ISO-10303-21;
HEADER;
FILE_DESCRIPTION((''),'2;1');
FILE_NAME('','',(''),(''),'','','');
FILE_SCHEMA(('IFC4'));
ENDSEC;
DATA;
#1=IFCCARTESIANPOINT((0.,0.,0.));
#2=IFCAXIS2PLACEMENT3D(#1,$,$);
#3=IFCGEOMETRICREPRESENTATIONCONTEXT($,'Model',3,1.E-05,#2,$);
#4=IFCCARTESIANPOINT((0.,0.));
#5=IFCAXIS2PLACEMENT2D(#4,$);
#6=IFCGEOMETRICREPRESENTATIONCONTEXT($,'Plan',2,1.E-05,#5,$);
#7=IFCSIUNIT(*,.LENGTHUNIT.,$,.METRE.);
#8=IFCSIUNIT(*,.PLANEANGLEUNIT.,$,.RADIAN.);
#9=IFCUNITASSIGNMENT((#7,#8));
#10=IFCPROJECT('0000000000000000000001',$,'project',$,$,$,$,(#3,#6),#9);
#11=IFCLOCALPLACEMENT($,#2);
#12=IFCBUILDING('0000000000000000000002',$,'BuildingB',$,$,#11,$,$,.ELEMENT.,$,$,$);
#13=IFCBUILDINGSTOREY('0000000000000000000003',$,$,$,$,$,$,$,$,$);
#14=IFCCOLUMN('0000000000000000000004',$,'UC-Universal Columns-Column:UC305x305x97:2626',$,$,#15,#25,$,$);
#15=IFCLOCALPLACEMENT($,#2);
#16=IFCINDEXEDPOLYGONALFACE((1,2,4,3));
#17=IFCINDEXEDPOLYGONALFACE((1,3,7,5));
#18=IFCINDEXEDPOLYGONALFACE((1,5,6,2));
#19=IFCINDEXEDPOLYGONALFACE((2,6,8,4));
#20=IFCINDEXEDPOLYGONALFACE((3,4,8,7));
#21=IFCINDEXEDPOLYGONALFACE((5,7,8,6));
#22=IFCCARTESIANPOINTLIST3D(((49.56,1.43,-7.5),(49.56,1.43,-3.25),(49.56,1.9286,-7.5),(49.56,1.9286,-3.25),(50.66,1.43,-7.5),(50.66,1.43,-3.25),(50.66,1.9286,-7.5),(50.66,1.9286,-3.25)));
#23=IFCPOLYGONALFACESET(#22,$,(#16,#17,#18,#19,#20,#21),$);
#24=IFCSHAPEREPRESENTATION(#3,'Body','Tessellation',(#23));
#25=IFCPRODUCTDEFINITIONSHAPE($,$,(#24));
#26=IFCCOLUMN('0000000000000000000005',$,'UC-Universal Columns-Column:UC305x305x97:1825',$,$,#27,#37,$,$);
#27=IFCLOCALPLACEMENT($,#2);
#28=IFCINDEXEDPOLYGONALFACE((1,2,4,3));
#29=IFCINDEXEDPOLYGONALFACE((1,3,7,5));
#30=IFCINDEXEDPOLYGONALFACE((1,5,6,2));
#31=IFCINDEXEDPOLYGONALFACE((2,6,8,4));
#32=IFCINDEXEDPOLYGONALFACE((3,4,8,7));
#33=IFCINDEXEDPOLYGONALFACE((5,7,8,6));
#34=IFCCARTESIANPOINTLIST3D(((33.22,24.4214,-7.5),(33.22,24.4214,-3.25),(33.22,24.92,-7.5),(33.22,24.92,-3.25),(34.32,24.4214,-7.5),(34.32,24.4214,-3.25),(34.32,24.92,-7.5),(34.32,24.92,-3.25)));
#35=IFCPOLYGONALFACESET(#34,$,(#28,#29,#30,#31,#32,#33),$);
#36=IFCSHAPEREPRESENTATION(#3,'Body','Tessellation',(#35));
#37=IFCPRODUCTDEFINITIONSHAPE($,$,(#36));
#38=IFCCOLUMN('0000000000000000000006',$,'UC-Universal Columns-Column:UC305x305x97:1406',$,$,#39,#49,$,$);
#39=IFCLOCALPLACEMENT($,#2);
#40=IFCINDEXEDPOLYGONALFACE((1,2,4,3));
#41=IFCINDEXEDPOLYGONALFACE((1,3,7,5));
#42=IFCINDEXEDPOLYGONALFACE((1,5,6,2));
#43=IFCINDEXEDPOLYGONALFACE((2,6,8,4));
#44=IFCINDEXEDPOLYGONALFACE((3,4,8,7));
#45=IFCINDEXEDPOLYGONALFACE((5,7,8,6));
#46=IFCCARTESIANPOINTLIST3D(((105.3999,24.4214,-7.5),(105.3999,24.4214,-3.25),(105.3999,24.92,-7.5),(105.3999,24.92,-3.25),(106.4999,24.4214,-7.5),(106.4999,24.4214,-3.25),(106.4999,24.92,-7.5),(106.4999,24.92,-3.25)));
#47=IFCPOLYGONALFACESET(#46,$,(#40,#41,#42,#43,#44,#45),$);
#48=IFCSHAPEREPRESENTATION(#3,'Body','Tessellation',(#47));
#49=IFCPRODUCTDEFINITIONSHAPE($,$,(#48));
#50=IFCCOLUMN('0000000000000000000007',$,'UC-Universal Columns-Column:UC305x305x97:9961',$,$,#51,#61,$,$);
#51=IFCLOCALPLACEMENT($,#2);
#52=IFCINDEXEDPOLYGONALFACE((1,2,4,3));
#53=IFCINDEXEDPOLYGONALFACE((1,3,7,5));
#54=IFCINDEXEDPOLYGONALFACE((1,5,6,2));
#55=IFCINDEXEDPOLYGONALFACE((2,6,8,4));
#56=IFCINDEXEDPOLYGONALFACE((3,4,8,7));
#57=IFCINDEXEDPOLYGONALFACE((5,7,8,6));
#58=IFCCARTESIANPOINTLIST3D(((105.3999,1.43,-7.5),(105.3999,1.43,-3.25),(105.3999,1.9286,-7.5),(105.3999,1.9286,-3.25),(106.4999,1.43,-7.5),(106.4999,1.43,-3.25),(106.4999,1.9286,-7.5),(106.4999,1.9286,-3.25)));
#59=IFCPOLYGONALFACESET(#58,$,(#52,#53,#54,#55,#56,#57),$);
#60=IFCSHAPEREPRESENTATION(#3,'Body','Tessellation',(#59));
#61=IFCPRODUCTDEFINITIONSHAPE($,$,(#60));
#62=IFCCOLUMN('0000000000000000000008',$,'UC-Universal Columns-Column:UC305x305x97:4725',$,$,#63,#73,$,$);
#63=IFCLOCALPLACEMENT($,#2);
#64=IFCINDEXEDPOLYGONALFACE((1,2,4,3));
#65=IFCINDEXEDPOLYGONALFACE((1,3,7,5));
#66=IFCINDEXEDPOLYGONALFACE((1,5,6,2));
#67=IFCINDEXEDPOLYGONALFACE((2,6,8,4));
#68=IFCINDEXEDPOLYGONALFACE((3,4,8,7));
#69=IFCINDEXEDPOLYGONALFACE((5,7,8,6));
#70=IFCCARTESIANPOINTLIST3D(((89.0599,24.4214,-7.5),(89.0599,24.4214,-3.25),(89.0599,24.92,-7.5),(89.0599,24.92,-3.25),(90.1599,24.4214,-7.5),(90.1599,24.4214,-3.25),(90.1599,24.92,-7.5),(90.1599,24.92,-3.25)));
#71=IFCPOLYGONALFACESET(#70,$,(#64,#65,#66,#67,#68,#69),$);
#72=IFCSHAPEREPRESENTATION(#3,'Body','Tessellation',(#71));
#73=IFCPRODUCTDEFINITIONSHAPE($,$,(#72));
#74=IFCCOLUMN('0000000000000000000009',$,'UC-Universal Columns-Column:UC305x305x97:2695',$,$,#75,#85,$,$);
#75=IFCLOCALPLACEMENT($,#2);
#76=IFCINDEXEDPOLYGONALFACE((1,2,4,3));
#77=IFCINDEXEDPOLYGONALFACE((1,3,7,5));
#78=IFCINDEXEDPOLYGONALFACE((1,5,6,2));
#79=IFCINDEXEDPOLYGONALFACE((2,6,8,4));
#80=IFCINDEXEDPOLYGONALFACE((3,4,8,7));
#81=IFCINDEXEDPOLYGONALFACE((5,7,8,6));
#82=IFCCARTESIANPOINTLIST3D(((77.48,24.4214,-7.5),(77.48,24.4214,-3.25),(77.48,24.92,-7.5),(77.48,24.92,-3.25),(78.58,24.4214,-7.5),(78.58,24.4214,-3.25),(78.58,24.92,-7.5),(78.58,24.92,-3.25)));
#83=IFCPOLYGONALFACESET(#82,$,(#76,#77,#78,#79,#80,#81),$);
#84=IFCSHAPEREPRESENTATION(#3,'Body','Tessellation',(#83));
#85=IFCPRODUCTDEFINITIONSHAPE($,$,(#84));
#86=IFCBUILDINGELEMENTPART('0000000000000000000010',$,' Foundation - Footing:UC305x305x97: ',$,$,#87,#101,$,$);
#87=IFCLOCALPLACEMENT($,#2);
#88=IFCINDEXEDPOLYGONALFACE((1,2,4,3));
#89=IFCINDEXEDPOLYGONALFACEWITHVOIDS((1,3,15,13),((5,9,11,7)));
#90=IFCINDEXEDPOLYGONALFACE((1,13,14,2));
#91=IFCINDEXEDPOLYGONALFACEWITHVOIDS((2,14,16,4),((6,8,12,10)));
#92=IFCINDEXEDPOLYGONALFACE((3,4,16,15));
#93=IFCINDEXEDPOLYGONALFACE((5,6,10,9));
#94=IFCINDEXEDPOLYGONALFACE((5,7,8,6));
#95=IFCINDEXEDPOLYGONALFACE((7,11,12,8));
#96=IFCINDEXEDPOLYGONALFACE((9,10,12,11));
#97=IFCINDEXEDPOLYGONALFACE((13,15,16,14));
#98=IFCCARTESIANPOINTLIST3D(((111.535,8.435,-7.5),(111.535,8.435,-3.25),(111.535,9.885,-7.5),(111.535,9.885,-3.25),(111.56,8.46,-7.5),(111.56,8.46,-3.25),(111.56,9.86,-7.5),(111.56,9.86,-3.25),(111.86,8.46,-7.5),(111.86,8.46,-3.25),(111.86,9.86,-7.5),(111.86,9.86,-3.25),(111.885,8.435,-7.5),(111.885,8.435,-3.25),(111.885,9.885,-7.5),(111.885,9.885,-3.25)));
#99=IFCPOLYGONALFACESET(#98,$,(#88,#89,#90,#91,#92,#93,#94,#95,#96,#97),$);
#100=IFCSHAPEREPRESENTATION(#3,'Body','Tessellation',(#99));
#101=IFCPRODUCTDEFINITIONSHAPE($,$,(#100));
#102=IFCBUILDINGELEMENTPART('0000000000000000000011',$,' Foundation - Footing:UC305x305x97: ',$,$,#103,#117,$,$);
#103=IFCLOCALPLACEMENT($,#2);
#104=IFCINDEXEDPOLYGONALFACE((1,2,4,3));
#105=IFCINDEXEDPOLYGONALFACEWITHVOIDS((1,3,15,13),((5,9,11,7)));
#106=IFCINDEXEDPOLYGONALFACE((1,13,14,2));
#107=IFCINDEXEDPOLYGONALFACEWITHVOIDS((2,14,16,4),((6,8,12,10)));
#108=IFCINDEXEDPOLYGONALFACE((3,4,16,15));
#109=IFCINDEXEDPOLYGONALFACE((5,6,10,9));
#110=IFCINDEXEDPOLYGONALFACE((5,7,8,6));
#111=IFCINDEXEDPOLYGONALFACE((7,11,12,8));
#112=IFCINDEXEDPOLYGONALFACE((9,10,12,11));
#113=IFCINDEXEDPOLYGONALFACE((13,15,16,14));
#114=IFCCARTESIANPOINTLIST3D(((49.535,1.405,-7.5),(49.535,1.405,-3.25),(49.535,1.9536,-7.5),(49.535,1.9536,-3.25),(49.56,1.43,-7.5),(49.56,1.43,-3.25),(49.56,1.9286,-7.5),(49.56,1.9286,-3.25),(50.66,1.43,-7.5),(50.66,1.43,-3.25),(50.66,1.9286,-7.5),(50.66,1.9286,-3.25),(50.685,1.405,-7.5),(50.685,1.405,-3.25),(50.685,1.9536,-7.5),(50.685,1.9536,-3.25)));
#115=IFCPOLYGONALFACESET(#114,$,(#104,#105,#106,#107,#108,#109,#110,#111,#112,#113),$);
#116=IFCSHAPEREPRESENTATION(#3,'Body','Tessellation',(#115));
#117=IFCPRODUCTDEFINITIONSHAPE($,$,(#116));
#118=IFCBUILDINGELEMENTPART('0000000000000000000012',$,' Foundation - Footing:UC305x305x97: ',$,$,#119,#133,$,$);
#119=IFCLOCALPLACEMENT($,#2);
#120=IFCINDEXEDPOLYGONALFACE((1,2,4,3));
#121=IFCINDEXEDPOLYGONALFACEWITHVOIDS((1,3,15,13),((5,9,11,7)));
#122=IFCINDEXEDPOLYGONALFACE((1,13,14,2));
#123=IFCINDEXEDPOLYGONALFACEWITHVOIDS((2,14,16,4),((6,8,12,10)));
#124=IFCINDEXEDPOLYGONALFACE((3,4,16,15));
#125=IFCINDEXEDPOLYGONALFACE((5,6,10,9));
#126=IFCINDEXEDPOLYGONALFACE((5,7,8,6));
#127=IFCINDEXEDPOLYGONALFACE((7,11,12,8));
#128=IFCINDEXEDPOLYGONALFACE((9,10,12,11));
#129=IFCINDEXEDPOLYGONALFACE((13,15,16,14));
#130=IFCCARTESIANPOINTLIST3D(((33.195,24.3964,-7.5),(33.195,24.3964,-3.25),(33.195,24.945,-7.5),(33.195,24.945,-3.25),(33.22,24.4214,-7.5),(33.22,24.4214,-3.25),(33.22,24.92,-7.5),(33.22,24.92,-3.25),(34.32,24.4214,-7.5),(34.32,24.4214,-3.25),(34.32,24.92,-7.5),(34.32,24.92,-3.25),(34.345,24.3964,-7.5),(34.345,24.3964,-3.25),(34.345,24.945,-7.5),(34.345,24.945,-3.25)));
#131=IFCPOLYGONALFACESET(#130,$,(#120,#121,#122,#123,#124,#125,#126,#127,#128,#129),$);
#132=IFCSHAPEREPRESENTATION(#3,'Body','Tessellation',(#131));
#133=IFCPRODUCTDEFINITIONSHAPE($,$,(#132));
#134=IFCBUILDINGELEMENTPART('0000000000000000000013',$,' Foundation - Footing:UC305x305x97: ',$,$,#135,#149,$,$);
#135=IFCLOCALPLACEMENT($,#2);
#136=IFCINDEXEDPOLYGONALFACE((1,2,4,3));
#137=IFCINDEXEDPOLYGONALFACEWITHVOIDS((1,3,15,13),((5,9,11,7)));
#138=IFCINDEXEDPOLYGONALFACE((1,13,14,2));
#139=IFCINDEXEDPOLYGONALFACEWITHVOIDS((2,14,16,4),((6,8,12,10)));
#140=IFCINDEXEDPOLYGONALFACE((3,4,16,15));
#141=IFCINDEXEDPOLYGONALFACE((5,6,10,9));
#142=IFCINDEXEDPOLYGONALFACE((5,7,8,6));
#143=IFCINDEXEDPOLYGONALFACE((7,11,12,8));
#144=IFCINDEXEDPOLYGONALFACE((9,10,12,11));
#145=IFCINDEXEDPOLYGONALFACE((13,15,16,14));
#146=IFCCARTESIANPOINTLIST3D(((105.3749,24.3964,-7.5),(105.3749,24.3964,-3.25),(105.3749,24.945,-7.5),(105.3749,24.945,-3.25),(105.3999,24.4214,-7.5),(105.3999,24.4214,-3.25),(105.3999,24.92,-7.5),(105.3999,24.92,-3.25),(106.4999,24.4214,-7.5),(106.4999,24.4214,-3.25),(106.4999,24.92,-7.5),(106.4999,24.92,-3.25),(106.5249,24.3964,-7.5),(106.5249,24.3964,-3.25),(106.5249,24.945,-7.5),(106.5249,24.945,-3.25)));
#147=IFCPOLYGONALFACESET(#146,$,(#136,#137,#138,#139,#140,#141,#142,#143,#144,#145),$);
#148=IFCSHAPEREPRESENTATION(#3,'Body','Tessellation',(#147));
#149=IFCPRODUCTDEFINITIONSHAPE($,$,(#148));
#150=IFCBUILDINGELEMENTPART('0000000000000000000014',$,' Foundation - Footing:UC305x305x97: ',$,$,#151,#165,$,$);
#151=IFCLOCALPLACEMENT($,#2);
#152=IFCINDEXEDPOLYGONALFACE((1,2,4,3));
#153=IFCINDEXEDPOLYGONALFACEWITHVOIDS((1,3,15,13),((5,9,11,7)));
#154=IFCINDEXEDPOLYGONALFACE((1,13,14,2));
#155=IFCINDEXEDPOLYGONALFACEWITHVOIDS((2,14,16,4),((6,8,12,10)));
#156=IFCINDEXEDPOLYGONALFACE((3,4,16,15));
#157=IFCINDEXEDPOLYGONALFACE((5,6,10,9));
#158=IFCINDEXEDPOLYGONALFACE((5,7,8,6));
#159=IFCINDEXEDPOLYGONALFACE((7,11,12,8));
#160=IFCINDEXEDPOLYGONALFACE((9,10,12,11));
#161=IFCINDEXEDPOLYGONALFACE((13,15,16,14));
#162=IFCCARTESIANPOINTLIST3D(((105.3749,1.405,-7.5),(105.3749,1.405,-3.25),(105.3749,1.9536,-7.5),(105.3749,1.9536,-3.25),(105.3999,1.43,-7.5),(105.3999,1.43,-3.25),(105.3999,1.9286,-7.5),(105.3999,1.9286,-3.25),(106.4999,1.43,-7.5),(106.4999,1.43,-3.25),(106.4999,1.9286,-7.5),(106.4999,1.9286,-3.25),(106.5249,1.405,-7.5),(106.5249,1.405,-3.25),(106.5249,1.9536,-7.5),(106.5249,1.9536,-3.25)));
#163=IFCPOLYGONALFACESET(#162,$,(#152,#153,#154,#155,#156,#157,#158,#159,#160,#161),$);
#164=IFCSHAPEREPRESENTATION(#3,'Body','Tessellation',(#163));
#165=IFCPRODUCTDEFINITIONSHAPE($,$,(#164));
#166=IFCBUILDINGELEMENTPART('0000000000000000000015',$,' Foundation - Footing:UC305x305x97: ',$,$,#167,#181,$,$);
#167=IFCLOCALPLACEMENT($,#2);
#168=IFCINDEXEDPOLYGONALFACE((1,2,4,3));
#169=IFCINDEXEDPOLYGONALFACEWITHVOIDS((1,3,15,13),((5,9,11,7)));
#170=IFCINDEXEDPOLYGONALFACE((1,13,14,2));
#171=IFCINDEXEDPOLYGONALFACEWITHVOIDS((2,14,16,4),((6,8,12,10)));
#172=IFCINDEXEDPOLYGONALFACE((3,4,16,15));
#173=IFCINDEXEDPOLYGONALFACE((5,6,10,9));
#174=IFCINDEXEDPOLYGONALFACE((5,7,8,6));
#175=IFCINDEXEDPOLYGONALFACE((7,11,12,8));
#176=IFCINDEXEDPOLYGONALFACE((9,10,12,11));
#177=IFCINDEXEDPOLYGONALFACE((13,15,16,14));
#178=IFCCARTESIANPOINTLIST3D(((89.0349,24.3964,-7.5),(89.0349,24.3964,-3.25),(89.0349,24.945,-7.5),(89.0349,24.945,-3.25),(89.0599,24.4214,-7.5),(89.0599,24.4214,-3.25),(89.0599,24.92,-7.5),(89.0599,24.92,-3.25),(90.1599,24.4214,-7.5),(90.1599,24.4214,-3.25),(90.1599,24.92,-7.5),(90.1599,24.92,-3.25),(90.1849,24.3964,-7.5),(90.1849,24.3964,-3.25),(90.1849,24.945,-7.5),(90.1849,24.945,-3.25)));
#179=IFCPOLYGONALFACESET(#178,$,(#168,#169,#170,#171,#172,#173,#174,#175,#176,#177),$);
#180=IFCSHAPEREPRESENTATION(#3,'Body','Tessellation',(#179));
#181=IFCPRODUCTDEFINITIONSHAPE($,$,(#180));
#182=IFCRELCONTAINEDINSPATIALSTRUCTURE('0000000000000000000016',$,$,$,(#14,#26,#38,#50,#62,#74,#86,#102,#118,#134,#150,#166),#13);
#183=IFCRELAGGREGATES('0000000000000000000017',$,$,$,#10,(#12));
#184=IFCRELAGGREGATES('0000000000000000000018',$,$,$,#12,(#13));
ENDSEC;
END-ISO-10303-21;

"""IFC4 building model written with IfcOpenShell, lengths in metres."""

from ifc_helpers import new_model, si_unit, origin, origin_2d, place, context, project, spatial, polyline, outline, extrude, element, save


model = new_model("IFC4")

# Units and contexts
model_context = context("Model", 3, precision=1e-05, world=origin())
plan_context = context("Plan", 2, precision=1e-05, world=origin_2d())
ifc_project = project(units=[si_unit("LENGTHUNIT", "METRE"), si_unit("PLANEANGLEUNIT", "RADIAN")], contexts=[model_context, plan_context])

# Building, storey
building_placement = place(None, origin())
building = spatial("IfcBuilding", under=ifc_project, at=building_placement, Name="BuildingB", CompositionType="ELEMENT")
storey = spatial("IfcBuildingStorey", under=building)

# Columns
element("IfcColumn", 1, inside=storey, Name="UC-Universal Columns-Column:UC305x305x97:2626", context=model_context, shape_type="SweptSolid", body=[
    extrude(outline(polyline([(50.66, 1.43, -7.5), (49.56, 1.43, -7.5), (49.56, 1.9286, -7.5), (50.66, 1.9286, -7.5), (50.66, 1.43, -7.5)])), None, (0.0, 0.0, 1.0), 4.25),
])
element("IfcColumn", 2, inside=storey, Name="UC-Universal Columns-Column:UC305x305x97:1825", context=model_context, shape_type="SweptSolid", body=[
    extrude(outline(polyline([(34.32, 24.4214, -7.5), (33.22, 24.4214, -7.5), (33.22, 24.92, -7.5), (34.32, 24.92, -7.5), (34.32, 24.4214, -7.5)])), None, (0.0, 0.0, 1.0), 4.25),
])
element("IfcColumn", 3, inside=storey, Name="UC-Universal Columns-Column:UC305x305x97:1406", context=model_context, shape_type="SweptSolid", body=[
    extrude(outline(polyline([(106.4999, 24.4214, -7.5), (105.3999, 24.4214, -7.5), (105.3999, 24.92, -7.5), (106.4999, 24.92, -7.5), (106.4999, 24.4214, -7.5)])), None, (0.0, 0.0, 1.0), 4.25),
])
element("IfcColumn", 4, inside=storey, Name="UC-Universal Columns-Column:UC305x305x97:9961", context=model_context, shape_type="SweptSolid", body=[
    extrude(outline(polyline([(106.4999, 1.43, -7.5), (105.3999, 1.43, -7.5), (105.3999, 1.9286, -7.5), (106.4999, 1.9286, -7.5), (106.4999, 1.43, -7.5)])), None, (0.0, 0.0, 1.0), 4.25),
])
element("IfcColumn", 5, inside=storey, Name="UC-Universal Columns-Column:UC305x305x97:4725", context=model_context, shape_type="SweptSolid", body=[
    extrude(outline(polyline([(90.1599, 24.4214, -7.5), (89.0599, 24.4214, -7.5), (89.0599, 24.92, -7.5), (90.1599, 24.92, -7.5), (90.1599, 24.4214, -7.5)])), None, (0.0, 0.0, 1.0), 4.25),
])
element("IfcColumn", 6, inside=storey, Name="UC-Universal Columns-Column:UC305x305x97:2695", context=model_context, shape_type="SweptSolid", body=[
    extrude(outline(polyline([(77.48, 24.4214, -7.5), (78.58, 24.4214, -7.5), (78.58, 24.92, -7.5), (77.48, 24.92, -7.5), (77.48, 24.4214, -7.5)])), None, (0.0, 0.0, 1.0), 4.25),
])

# Building element parts, openings
building_element_part_1 = element("IfcBuildingElementPart", 7, inside=storey, Name=" Foundation - Footing:UC305x305x97: ", context=model_context, shape_type="SweptSolid", body=[
    extrude(outline(polyline([(111.885, 8.435, -7.5), (111.535, 8.435, -7.5), (111.535, 9.885, -7.5), (111.885, 9.885, -7.5), (111.885, 8.435, -7.5)])), None, (0.0, 0.0, 1.0), 4.25),
])
element("IfcOpeningElement", 8, inside=storey, cuts=building_element_part_1, context=model_context, shape_type="SweptSolid", body=[
    extrude(outline(polyline([(111.86, 8.46, -7.5), (111.56, 8.46, -7.5), (111.56, 9.86, -7.5), (111.86, 9.86, -7.5), (111.86, 8.46, -7.5)])), None, (0.0, 0.0, 1.0), 4.25),
])
building_element_part_2 = element("IfcBuildingElementPart", 9, inside=storey, Name=" Foundation - Footing:UC305x305x97: ", context=model_context, shape_type="SweptSolid", body=[
    extrude(outline(polyline([(50.685, 1.405, -7.5), (49.535, 1.405, -7.5), (49.535, 1.9536, -7.5), (50.685, 1.9536, -7.5), (50.685, 1.405, -7.5)])), None, (0.0, 0.0, 1.0), 4.25),
])
element("IfcOpeningElement", 10, inside=storey, cuts=building_element_part_2, context=model_context, shape_type="SweptSolid", body=[
    extrude(outline(polyline([(50.66, 1.43, -7.5), (49.56, 1.43, -7.5), (49.56, 1.9286, -7.5), (50.66, 1.9286, -7.5), (50.66, 1.43, -7.5)])), None, (0.0, 0.0, 1.0), 4.25),
])
building_element_part_3 = element("IfcBuildingElementPart", 11, inside=storey, Name=" Foundation - Footing:UC305x305x97: ", context=model_context, shape_type="SweptSolid", body=[
    extrude(outline(polyline([(34.345, 24.3964, -7.5), (33.195, 24.3964, -7.5), (33.195, 24.945, -7.5), (34.345, 24.945, -7.5), (34.345, 24.3964, -7.5)])), None, (0.0, 0.0, 1.0), 4.25),
])
element("IfcOpeningElement", 12, inside=storey, cuts=building_element_part_3, context=model_context, shape_type="SweptSolid", body=[
    extrude(outline(polyline([(34.32, 24.4214, -7.5), (33.22, 24.4214, -7.5), (33.22, 24.92, -7.5), (34.32, 24.92, -7.5), (34.32, 24.4214, -7.5)])), None, (0.0, 0.0, 1.0), 4.25),
])
building_element_part_4 = element("IfcBuildingElementPart", 13, inside=storey, Name=" Foundation - Footing:UC305x305x97: ", context=model_context, shape_type="SweptSolid", body=[
    extrude(outline(polyline([(106.5249, 24.3964, -7.5), (105.3749, 24.3964, -7.5), (105.3749, 24.945, -7.5), (106.5249, 24.945, -7.5), (106.5249, 24.3964, -7.5)])), None, (0.0, 0.0, 1.0), 4.25),
])
element("IfcOpeningElement", 14, inside=storey, cuts=building_element_part_4, context=model_context, shape_type="SweptSolid", body=[
    extrude(outline(polyline([(106.4999, 24.4214, -7.5), (105.3999, 24.4214, -7.5), (105.3999, 24.92, -7.5), (106.4999, 24.92, -7.5), (106.4999, 24.4214, -7.5)])), None, (0.0, 0.0, 1.0), 4.25),
])
building_element_part_5 = element("IfcBuildingElementPart", 15, inside=storey, Name=" Foundation - Footing:UC305x305x97: ", context=model_context, shape_type="SweptSolid", body=[
    extrude(outline(polyline([(106.5249, 1.405, -7.5), (105.3749, 1.405, -7.5), (105.3749, 1.9536, -7.5), (106.5249, 1.9536, -7.5), (106.5249, 1.405, -7.5)])), None, (0.0, 0.0, 1.0), 4.25),
])
element("IfcOpeningElement", 16, inside=storey, cuts=building_element_part_5, context=model_context, shape_type="SweptSolid", body=[
    extrude(outline(polyline([(106.4999, 1.43, -7.5), (105.3999, 1.43, -7.5), (105.3999, 1.9286, -7.5), (106.4999, 1.9286, -7.5), (106.4999, 1.43, -7.5)])), None, (0.0, 0.0, 1.0), 4.25),
])
building_element_part_6 = element("IfcBuildingElementPart", 17, inside=storey, Name=" Foundation - Footing:UC305x305x97: ", context=model_context, shape_type="SweptSolid", body=[
    extrude(outline(polyline([(90.1849, 24.3964, -7.5), (89.0349, 24.3964, -7.5), (89.0349, 24.945, -7.5), (90.1849, 24.945, -7.5), (90.1849, 24.3964, -7.5)])), None, (0.0, 0.0, 1.0), 4.25),
])
element("IfcOpeningElement", 18, inside=storey, cuts=building_element_part_6, context=model_context, shape_type="SweptSolid", body=[
    extrude(outline(polyline([(90.1599, 24.4214, -7.5), (89.0599, 24.4214, -7.5), (89.0599, 24.92, -7.5), (90.1599, 24.92, -7.5), (90.1599, 24.4214, -7.5)])), None, (0.0, 0.0, 1.0), 4.25),
])

save(model, "model.ifc")
